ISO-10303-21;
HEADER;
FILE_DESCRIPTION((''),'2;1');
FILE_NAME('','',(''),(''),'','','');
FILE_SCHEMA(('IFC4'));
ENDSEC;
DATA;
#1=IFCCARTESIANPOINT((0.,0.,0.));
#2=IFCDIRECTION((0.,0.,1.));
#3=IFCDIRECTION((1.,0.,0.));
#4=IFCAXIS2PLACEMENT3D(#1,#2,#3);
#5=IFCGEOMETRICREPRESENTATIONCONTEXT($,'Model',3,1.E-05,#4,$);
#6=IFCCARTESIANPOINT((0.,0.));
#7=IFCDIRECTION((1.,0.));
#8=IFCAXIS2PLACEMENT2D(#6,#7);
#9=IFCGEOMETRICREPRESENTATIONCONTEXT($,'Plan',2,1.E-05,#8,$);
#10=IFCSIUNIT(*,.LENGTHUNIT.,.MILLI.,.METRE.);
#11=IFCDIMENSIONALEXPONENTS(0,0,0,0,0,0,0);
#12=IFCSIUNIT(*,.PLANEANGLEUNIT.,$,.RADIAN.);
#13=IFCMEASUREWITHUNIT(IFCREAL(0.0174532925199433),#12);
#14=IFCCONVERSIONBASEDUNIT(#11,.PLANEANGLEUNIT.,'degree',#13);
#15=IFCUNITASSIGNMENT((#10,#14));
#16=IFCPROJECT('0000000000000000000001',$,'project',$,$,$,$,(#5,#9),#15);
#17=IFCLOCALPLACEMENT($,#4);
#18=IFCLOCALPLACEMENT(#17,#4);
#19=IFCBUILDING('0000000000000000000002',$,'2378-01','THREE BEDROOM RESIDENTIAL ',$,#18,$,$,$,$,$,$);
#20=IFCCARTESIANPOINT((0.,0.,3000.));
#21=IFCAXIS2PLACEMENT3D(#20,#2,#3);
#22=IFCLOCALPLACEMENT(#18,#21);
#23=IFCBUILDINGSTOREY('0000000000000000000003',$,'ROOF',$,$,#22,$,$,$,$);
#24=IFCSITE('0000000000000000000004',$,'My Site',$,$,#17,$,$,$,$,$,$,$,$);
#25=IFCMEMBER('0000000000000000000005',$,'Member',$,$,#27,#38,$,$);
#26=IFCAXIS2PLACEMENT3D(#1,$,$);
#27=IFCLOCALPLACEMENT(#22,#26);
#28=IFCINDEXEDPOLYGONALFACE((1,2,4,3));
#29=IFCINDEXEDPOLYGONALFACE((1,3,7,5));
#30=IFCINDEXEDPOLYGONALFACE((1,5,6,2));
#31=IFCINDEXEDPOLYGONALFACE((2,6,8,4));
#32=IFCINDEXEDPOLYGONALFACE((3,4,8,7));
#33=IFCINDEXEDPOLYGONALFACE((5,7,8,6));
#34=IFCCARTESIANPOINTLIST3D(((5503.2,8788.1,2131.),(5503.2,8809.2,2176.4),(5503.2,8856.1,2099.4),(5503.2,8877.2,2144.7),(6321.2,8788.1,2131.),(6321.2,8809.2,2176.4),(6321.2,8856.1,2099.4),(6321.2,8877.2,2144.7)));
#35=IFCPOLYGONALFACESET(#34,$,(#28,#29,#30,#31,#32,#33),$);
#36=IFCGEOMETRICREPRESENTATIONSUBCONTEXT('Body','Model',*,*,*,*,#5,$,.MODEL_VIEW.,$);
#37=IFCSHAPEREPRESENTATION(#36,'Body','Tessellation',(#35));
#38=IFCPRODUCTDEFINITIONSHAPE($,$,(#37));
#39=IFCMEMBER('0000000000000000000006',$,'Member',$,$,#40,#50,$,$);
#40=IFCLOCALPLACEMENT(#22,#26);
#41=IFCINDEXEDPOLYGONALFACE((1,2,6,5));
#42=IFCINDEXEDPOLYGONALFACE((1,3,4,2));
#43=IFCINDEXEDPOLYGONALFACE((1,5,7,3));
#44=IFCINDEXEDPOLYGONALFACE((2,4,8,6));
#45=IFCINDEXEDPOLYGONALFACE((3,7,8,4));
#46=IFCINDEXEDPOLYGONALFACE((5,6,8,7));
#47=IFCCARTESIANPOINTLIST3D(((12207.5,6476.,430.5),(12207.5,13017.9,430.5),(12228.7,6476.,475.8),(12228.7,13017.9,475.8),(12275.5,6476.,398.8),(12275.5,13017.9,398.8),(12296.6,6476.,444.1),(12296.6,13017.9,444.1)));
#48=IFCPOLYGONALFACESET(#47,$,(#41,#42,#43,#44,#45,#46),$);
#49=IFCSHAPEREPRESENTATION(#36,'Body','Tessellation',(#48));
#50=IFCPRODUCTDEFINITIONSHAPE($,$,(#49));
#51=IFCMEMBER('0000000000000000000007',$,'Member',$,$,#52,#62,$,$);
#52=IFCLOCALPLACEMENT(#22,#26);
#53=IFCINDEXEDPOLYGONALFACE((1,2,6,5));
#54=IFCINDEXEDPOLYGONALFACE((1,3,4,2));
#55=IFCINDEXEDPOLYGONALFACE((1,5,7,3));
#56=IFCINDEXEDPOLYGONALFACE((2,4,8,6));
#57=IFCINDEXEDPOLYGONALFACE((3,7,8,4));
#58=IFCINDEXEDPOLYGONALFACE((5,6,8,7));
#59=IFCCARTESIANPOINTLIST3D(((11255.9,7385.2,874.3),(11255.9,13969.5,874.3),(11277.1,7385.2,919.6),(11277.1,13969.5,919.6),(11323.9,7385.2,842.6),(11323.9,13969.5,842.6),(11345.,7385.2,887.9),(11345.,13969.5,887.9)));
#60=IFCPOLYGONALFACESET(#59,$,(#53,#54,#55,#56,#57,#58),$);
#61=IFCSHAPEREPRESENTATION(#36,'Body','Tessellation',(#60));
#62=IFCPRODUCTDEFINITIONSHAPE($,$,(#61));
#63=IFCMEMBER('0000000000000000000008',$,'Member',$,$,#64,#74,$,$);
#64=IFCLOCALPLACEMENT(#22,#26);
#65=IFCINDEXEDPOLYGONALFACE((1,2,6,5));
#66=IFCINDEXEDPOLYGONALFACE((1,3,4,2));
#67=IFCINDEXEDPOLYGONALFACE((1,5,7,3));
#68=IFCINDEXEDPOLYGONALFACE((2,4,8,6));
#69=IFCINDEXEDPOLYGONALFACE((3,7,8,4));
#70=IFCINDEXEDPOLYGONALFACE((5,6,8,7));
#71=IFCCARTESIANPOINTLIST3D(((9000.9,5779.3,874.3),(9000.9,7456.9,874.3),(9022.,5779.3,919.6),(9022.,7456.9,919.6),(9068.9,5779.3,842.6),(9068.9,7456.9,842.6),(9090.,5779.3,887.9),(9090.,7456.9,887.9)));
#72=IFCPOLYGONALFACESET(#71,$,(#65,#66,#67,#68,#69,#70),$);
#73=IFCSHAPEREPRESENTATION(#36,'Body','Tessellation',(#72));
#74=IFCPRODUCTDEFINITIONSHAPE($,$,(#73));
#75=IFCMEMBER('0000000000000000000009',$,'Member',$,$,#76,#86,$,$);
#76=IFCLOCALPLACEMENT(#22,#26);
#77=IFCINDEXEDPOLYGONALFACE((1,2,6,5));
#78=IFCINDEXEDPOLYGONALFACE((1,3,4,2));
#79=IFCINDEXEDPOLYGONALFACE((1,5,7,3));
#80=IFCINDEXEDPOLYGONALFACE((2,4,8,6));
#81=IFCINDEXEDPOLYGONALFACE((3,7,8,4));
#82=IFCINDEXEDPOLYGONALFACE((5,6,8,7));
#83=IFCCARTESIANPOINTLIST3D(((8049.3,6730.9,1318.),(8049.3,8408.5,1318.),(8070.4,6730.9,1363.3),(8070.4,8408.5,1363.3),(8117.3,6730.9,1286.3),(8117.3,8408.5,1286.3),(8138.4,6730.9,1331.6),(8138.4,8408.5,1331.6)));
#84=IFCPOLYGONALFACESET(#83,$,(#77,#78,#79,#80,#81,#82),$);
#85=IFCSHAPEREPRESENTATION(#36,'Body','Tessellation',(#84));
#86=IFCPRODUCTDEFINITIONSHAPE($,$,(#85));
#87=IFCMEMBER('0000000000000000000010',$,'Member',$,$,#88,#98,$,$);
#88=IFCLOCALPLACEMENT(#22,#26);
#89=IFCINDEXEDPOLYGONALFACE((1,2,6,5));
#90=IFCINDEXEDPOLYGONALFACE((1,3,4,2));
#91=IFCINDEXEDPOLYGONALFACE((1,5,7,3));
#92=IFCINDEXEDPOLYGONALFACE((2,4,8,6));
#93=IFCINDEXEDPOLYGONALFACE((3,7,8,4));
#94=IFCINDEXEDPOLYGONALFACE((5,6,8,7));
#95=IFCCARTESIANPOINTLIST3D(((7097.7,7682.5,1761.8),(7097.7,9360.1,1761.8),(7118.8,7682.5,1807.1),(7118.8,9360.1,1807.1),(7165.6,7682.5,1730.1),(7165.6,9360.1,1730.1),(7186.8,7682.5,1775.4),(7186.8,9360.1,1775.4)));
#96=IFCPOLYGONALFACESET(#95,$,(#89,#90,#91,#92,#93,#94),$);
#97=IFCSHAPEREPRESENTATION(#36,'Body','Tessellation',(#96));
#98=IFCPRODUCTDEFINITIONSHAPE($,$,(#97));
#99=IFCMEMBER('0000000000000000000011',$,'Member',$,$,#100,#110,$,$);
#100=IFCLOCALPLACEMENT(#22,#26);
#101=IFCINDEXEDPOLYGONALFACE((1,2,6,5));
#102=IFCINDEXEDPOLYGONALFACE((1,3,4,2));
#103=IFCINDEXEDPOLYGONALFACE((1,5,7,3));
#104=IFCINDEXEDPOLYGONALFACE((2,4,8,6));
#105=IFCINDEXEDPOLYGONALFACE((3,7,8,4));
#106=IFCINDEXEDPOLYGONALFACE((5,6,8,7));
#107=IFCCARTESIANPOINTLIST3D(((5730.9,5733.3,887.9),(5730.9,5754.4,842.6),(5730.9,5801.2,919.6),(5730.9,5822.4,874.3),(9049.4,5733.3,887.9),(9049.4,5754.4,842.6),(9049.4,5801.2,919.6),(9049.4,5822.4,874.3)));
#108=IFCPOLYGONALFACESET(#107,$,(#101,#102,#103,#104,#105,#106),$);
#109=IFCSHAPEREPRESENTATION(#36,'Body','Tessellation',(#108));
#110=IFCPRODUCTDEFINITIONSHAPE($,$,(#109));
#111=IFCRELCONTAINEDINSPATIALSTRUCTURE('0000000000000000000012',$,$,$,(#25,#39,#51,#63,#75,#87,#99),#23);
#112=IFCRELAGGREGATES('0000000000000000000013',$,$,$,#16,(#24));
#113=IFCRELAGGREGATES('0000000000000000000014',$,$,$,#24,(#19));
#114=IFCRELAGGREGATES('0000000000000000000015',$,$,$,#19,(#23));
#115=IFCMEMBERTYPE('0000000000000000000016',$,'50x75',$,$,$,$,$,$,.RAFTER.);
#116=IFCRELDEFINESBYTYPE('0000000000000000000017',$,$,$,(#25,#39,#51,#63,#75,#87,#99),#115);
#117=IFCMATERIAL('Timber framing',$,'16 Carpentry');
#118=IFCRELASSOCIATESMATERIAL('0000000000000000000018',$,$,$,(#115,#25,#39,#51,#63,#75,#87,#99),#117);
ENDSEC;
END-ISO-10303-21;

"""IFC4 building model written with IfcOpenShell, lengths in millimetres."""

from ifc_helpers import new_model, entity, si_unit, converted_unit, frame, origin_with_axes, origin_2d_with_axis, place, context, subcontext, project, spatial, rectangle, extrude, material, material_profile, profile_set, profile_usage, type_object, element, save


model = new_model("IFC4")

# Units and contexts
model_context = context("Model", 3, precision=1e-05, world=origin_with_axes())
plan_context = context("Plan", 2, precision=1e-05, world=origin_2d_with_axis())
body_context = subcontext(model_context, "Body", "Model", "MODEL_VIEW")
ifc_project = project(units=[si_unit("LENGTHUNIT", "METRE", prefix="MILLI"), converted_unit("PLANEANGLEUNIT", "degree", entity("IfcReal", 0.0174532925199433), si_unit("PLANEANGLEUNIT", "RADIAN"), dimensions=[0, 0, 0, 0, 0, 0, 0])], contexts=[model_context, plan_context])

# Site, building, storey
site_placement = place(None, origin_with_axes())
site = spatial("IfcSite", under=ifc_project, at=site_placement, Name="My Site")
building_placement = place(site_placement, origin_with_axes())
building = spatial("IfcBuilding", under=site, at=building_placement, Name="2378-01", Description="THREE BEDROOM RESIDENTIAL ")
storey_placement = place(building_placement, frame((0.0, 0.0, 3000.0), z_axis=(0.0, 0.0, 1.0), x_axis=(1.0, 0.0, 0.0)))
storey = spatial("IfcBuildingStorey", under=building, at=storey_placement, Name="ROOF")

# Members
ifc_material_1 = material(Name="Timber framing", Category="16 Carpentry")
ifc_material_profile_1 = material_profile(ifc_material_1, rectangle(XDim=50.0, YDim=75.0), Name="Lumber2", Category="Substrate", Priority=2)
ifc_profile_set_1 = profile_set([ifc_material_profile_1])
member_type_1 = type_object("IfcMemberType", Name="50x75", PredefinedType="RAFTER", material=ifc_profile_set_1)
ifc_profile_usage_1 = profile_usage(ifc_profile_set_1, cardinal=5)
member_1_placement = place(storey_placement, frame((6321.2, 8832.6, 2137.9), z_axis=(-1.0, 0.0, 0.0), x_axis=(0.0, -0.422618, -0.906308)))
element("IfcMember", 1, at=member_1_placement, inside=storey, type_object=member_type_1, material=ifc_profile_usage_1, Name="Member", context=body_context, shape_type="SweptSolid", body=[
    extrude(rectangle(XDim=50.0, YDim=75.0), origin_with_axes(), (0.0, 0.0, 1.0), 817.9),
])
ifc_profile_usage_2 = profile_usage(ifc_profile_set_1, cardinal=5)
member_2_placement = place(storey_placement, frame((12252.1, 6476.0, 437.3), z_axis=(0.0, 1.0, 0.0), x_axis=(-0.422618, 0.0, -0.906308)))
element("IfcMember", 2, at=member_2_placement, inside=storey, type_object=member_type_1, material=ifc_profile_usage_2, Name="Member", context=body_context, shape_type="SweptSolid", body=[
    extrude(rectangle(XDim=50.0, YDim=75.0), origin_with_axes(), (0.0, 0.0, 1.0), 6541.9),
])
ifc_profile_usage_3 = profile_usage(ifc_profile_set_1, cardinal=5)
member_3_placement = place(storey_placement, frame((11300.5, 7385.2, 881.1), z_axis=(0.0, 1.0, 0.0), x_axis=(-0.422618, 0.0, -0.906308)))
element("IfcMember", 3, at=member_3_placement, inside=storey, type_object=member_type_1, material=ifc_profile_usage_3, Name="Member", context=body_context, shape_type="SweptSolid", body=[
    extrude(rectangle(XDim=50.0, YDim=75.0), origin_with_axes(), (0.0, 0.0, 1.0), 6584.3),
])
ifc_profile_usage_4 = profile_usage(ifc_profile_set_1, cardinal=5)
member_4_placement = place(storey_placement, frame((9045.5, 5779.3, 881.1), z_axis=(0.0, 1.0, 0.0), x_axis=(-0.422618, 0.0, -0.906308)))
element("IfcMember", 4, at=member_4_placement, inside=storey, type_object=member_type_1, material=ifc_profile_usage_4, Name="Member", context=body_context, shape_type="SweptSolid", body=[
    extrude(rectangle(XDim=50.0, YDim=75.0), origin_with_axes(), (0.0, 0.0, 1.0), 1677.6),
])
ifc_profile_usage_5 = profile_usage(ifc_profile_set_1, cardinal=5)
member_5_placement = place(storey_placement, frame((8093.8, 6730.9, 1324.8), z_axis=(0.0, 1.0, 0.0), x_axis=(-0.422618, 0.0, -0.906308)))
element("IfcMember", 5, at=member_5_placement, inside=storey, type_object=member_type_1, material=ifc_profile_usage_5, Name="Member", context=body_context, shape_type="SweptSolid", body=[
    extrude(rectangle(XDim=50.0, YDim=75.0), origin_with_axes(), (0.0, 0.0, 1.0), 1677.6),
])
ifc_profile_usage_6 = profile_usage(ifc_profile_set_1, cardinal=5)
member_6_placement = place(storey_placement, frame((7142.2, 7682.5, 1768.6), z_axis=(0.0, 1.0, 0.0), x_axis=(-0.422618, 0.0, -0.906308)))
element("IfcMember", 6, at=member_6_placement, inside=storey, type_object=member_type_1, material=ifc_profile_usage_6, Name="Member", context=body_context, shape_type="SweptSolid", body=[
    extrude(rectangle(XDim=50.0, YDim=75.0), origin_with_axes(), (0.0, 0.0, 1.0), 1677.6),
])
ifc_profile_usage_7 = profile_usage(ifc_profile_set_1, cardinal=5)
member_7_placement = place(storey_placement, frame((5730.9, 5777.8, 881.1), z_axis=(1.0, 0.0, 0.0), x_axis=(0.0, 0.422618, -0.906308)))
element("IfcMember", 7, at=member_7_placement, inside=storey, type_object=member_type_1, material=ifc_profile_usage_7, Name="Member", context=body_context, shape_type="SweptSolid", body=[
    extrude(rectangle(XDim=50.0, YDim=75.0), origin_with_axes(), (0.0, 0.0, 1.0), 3318.5),
])

save(model, "model.ifc")
